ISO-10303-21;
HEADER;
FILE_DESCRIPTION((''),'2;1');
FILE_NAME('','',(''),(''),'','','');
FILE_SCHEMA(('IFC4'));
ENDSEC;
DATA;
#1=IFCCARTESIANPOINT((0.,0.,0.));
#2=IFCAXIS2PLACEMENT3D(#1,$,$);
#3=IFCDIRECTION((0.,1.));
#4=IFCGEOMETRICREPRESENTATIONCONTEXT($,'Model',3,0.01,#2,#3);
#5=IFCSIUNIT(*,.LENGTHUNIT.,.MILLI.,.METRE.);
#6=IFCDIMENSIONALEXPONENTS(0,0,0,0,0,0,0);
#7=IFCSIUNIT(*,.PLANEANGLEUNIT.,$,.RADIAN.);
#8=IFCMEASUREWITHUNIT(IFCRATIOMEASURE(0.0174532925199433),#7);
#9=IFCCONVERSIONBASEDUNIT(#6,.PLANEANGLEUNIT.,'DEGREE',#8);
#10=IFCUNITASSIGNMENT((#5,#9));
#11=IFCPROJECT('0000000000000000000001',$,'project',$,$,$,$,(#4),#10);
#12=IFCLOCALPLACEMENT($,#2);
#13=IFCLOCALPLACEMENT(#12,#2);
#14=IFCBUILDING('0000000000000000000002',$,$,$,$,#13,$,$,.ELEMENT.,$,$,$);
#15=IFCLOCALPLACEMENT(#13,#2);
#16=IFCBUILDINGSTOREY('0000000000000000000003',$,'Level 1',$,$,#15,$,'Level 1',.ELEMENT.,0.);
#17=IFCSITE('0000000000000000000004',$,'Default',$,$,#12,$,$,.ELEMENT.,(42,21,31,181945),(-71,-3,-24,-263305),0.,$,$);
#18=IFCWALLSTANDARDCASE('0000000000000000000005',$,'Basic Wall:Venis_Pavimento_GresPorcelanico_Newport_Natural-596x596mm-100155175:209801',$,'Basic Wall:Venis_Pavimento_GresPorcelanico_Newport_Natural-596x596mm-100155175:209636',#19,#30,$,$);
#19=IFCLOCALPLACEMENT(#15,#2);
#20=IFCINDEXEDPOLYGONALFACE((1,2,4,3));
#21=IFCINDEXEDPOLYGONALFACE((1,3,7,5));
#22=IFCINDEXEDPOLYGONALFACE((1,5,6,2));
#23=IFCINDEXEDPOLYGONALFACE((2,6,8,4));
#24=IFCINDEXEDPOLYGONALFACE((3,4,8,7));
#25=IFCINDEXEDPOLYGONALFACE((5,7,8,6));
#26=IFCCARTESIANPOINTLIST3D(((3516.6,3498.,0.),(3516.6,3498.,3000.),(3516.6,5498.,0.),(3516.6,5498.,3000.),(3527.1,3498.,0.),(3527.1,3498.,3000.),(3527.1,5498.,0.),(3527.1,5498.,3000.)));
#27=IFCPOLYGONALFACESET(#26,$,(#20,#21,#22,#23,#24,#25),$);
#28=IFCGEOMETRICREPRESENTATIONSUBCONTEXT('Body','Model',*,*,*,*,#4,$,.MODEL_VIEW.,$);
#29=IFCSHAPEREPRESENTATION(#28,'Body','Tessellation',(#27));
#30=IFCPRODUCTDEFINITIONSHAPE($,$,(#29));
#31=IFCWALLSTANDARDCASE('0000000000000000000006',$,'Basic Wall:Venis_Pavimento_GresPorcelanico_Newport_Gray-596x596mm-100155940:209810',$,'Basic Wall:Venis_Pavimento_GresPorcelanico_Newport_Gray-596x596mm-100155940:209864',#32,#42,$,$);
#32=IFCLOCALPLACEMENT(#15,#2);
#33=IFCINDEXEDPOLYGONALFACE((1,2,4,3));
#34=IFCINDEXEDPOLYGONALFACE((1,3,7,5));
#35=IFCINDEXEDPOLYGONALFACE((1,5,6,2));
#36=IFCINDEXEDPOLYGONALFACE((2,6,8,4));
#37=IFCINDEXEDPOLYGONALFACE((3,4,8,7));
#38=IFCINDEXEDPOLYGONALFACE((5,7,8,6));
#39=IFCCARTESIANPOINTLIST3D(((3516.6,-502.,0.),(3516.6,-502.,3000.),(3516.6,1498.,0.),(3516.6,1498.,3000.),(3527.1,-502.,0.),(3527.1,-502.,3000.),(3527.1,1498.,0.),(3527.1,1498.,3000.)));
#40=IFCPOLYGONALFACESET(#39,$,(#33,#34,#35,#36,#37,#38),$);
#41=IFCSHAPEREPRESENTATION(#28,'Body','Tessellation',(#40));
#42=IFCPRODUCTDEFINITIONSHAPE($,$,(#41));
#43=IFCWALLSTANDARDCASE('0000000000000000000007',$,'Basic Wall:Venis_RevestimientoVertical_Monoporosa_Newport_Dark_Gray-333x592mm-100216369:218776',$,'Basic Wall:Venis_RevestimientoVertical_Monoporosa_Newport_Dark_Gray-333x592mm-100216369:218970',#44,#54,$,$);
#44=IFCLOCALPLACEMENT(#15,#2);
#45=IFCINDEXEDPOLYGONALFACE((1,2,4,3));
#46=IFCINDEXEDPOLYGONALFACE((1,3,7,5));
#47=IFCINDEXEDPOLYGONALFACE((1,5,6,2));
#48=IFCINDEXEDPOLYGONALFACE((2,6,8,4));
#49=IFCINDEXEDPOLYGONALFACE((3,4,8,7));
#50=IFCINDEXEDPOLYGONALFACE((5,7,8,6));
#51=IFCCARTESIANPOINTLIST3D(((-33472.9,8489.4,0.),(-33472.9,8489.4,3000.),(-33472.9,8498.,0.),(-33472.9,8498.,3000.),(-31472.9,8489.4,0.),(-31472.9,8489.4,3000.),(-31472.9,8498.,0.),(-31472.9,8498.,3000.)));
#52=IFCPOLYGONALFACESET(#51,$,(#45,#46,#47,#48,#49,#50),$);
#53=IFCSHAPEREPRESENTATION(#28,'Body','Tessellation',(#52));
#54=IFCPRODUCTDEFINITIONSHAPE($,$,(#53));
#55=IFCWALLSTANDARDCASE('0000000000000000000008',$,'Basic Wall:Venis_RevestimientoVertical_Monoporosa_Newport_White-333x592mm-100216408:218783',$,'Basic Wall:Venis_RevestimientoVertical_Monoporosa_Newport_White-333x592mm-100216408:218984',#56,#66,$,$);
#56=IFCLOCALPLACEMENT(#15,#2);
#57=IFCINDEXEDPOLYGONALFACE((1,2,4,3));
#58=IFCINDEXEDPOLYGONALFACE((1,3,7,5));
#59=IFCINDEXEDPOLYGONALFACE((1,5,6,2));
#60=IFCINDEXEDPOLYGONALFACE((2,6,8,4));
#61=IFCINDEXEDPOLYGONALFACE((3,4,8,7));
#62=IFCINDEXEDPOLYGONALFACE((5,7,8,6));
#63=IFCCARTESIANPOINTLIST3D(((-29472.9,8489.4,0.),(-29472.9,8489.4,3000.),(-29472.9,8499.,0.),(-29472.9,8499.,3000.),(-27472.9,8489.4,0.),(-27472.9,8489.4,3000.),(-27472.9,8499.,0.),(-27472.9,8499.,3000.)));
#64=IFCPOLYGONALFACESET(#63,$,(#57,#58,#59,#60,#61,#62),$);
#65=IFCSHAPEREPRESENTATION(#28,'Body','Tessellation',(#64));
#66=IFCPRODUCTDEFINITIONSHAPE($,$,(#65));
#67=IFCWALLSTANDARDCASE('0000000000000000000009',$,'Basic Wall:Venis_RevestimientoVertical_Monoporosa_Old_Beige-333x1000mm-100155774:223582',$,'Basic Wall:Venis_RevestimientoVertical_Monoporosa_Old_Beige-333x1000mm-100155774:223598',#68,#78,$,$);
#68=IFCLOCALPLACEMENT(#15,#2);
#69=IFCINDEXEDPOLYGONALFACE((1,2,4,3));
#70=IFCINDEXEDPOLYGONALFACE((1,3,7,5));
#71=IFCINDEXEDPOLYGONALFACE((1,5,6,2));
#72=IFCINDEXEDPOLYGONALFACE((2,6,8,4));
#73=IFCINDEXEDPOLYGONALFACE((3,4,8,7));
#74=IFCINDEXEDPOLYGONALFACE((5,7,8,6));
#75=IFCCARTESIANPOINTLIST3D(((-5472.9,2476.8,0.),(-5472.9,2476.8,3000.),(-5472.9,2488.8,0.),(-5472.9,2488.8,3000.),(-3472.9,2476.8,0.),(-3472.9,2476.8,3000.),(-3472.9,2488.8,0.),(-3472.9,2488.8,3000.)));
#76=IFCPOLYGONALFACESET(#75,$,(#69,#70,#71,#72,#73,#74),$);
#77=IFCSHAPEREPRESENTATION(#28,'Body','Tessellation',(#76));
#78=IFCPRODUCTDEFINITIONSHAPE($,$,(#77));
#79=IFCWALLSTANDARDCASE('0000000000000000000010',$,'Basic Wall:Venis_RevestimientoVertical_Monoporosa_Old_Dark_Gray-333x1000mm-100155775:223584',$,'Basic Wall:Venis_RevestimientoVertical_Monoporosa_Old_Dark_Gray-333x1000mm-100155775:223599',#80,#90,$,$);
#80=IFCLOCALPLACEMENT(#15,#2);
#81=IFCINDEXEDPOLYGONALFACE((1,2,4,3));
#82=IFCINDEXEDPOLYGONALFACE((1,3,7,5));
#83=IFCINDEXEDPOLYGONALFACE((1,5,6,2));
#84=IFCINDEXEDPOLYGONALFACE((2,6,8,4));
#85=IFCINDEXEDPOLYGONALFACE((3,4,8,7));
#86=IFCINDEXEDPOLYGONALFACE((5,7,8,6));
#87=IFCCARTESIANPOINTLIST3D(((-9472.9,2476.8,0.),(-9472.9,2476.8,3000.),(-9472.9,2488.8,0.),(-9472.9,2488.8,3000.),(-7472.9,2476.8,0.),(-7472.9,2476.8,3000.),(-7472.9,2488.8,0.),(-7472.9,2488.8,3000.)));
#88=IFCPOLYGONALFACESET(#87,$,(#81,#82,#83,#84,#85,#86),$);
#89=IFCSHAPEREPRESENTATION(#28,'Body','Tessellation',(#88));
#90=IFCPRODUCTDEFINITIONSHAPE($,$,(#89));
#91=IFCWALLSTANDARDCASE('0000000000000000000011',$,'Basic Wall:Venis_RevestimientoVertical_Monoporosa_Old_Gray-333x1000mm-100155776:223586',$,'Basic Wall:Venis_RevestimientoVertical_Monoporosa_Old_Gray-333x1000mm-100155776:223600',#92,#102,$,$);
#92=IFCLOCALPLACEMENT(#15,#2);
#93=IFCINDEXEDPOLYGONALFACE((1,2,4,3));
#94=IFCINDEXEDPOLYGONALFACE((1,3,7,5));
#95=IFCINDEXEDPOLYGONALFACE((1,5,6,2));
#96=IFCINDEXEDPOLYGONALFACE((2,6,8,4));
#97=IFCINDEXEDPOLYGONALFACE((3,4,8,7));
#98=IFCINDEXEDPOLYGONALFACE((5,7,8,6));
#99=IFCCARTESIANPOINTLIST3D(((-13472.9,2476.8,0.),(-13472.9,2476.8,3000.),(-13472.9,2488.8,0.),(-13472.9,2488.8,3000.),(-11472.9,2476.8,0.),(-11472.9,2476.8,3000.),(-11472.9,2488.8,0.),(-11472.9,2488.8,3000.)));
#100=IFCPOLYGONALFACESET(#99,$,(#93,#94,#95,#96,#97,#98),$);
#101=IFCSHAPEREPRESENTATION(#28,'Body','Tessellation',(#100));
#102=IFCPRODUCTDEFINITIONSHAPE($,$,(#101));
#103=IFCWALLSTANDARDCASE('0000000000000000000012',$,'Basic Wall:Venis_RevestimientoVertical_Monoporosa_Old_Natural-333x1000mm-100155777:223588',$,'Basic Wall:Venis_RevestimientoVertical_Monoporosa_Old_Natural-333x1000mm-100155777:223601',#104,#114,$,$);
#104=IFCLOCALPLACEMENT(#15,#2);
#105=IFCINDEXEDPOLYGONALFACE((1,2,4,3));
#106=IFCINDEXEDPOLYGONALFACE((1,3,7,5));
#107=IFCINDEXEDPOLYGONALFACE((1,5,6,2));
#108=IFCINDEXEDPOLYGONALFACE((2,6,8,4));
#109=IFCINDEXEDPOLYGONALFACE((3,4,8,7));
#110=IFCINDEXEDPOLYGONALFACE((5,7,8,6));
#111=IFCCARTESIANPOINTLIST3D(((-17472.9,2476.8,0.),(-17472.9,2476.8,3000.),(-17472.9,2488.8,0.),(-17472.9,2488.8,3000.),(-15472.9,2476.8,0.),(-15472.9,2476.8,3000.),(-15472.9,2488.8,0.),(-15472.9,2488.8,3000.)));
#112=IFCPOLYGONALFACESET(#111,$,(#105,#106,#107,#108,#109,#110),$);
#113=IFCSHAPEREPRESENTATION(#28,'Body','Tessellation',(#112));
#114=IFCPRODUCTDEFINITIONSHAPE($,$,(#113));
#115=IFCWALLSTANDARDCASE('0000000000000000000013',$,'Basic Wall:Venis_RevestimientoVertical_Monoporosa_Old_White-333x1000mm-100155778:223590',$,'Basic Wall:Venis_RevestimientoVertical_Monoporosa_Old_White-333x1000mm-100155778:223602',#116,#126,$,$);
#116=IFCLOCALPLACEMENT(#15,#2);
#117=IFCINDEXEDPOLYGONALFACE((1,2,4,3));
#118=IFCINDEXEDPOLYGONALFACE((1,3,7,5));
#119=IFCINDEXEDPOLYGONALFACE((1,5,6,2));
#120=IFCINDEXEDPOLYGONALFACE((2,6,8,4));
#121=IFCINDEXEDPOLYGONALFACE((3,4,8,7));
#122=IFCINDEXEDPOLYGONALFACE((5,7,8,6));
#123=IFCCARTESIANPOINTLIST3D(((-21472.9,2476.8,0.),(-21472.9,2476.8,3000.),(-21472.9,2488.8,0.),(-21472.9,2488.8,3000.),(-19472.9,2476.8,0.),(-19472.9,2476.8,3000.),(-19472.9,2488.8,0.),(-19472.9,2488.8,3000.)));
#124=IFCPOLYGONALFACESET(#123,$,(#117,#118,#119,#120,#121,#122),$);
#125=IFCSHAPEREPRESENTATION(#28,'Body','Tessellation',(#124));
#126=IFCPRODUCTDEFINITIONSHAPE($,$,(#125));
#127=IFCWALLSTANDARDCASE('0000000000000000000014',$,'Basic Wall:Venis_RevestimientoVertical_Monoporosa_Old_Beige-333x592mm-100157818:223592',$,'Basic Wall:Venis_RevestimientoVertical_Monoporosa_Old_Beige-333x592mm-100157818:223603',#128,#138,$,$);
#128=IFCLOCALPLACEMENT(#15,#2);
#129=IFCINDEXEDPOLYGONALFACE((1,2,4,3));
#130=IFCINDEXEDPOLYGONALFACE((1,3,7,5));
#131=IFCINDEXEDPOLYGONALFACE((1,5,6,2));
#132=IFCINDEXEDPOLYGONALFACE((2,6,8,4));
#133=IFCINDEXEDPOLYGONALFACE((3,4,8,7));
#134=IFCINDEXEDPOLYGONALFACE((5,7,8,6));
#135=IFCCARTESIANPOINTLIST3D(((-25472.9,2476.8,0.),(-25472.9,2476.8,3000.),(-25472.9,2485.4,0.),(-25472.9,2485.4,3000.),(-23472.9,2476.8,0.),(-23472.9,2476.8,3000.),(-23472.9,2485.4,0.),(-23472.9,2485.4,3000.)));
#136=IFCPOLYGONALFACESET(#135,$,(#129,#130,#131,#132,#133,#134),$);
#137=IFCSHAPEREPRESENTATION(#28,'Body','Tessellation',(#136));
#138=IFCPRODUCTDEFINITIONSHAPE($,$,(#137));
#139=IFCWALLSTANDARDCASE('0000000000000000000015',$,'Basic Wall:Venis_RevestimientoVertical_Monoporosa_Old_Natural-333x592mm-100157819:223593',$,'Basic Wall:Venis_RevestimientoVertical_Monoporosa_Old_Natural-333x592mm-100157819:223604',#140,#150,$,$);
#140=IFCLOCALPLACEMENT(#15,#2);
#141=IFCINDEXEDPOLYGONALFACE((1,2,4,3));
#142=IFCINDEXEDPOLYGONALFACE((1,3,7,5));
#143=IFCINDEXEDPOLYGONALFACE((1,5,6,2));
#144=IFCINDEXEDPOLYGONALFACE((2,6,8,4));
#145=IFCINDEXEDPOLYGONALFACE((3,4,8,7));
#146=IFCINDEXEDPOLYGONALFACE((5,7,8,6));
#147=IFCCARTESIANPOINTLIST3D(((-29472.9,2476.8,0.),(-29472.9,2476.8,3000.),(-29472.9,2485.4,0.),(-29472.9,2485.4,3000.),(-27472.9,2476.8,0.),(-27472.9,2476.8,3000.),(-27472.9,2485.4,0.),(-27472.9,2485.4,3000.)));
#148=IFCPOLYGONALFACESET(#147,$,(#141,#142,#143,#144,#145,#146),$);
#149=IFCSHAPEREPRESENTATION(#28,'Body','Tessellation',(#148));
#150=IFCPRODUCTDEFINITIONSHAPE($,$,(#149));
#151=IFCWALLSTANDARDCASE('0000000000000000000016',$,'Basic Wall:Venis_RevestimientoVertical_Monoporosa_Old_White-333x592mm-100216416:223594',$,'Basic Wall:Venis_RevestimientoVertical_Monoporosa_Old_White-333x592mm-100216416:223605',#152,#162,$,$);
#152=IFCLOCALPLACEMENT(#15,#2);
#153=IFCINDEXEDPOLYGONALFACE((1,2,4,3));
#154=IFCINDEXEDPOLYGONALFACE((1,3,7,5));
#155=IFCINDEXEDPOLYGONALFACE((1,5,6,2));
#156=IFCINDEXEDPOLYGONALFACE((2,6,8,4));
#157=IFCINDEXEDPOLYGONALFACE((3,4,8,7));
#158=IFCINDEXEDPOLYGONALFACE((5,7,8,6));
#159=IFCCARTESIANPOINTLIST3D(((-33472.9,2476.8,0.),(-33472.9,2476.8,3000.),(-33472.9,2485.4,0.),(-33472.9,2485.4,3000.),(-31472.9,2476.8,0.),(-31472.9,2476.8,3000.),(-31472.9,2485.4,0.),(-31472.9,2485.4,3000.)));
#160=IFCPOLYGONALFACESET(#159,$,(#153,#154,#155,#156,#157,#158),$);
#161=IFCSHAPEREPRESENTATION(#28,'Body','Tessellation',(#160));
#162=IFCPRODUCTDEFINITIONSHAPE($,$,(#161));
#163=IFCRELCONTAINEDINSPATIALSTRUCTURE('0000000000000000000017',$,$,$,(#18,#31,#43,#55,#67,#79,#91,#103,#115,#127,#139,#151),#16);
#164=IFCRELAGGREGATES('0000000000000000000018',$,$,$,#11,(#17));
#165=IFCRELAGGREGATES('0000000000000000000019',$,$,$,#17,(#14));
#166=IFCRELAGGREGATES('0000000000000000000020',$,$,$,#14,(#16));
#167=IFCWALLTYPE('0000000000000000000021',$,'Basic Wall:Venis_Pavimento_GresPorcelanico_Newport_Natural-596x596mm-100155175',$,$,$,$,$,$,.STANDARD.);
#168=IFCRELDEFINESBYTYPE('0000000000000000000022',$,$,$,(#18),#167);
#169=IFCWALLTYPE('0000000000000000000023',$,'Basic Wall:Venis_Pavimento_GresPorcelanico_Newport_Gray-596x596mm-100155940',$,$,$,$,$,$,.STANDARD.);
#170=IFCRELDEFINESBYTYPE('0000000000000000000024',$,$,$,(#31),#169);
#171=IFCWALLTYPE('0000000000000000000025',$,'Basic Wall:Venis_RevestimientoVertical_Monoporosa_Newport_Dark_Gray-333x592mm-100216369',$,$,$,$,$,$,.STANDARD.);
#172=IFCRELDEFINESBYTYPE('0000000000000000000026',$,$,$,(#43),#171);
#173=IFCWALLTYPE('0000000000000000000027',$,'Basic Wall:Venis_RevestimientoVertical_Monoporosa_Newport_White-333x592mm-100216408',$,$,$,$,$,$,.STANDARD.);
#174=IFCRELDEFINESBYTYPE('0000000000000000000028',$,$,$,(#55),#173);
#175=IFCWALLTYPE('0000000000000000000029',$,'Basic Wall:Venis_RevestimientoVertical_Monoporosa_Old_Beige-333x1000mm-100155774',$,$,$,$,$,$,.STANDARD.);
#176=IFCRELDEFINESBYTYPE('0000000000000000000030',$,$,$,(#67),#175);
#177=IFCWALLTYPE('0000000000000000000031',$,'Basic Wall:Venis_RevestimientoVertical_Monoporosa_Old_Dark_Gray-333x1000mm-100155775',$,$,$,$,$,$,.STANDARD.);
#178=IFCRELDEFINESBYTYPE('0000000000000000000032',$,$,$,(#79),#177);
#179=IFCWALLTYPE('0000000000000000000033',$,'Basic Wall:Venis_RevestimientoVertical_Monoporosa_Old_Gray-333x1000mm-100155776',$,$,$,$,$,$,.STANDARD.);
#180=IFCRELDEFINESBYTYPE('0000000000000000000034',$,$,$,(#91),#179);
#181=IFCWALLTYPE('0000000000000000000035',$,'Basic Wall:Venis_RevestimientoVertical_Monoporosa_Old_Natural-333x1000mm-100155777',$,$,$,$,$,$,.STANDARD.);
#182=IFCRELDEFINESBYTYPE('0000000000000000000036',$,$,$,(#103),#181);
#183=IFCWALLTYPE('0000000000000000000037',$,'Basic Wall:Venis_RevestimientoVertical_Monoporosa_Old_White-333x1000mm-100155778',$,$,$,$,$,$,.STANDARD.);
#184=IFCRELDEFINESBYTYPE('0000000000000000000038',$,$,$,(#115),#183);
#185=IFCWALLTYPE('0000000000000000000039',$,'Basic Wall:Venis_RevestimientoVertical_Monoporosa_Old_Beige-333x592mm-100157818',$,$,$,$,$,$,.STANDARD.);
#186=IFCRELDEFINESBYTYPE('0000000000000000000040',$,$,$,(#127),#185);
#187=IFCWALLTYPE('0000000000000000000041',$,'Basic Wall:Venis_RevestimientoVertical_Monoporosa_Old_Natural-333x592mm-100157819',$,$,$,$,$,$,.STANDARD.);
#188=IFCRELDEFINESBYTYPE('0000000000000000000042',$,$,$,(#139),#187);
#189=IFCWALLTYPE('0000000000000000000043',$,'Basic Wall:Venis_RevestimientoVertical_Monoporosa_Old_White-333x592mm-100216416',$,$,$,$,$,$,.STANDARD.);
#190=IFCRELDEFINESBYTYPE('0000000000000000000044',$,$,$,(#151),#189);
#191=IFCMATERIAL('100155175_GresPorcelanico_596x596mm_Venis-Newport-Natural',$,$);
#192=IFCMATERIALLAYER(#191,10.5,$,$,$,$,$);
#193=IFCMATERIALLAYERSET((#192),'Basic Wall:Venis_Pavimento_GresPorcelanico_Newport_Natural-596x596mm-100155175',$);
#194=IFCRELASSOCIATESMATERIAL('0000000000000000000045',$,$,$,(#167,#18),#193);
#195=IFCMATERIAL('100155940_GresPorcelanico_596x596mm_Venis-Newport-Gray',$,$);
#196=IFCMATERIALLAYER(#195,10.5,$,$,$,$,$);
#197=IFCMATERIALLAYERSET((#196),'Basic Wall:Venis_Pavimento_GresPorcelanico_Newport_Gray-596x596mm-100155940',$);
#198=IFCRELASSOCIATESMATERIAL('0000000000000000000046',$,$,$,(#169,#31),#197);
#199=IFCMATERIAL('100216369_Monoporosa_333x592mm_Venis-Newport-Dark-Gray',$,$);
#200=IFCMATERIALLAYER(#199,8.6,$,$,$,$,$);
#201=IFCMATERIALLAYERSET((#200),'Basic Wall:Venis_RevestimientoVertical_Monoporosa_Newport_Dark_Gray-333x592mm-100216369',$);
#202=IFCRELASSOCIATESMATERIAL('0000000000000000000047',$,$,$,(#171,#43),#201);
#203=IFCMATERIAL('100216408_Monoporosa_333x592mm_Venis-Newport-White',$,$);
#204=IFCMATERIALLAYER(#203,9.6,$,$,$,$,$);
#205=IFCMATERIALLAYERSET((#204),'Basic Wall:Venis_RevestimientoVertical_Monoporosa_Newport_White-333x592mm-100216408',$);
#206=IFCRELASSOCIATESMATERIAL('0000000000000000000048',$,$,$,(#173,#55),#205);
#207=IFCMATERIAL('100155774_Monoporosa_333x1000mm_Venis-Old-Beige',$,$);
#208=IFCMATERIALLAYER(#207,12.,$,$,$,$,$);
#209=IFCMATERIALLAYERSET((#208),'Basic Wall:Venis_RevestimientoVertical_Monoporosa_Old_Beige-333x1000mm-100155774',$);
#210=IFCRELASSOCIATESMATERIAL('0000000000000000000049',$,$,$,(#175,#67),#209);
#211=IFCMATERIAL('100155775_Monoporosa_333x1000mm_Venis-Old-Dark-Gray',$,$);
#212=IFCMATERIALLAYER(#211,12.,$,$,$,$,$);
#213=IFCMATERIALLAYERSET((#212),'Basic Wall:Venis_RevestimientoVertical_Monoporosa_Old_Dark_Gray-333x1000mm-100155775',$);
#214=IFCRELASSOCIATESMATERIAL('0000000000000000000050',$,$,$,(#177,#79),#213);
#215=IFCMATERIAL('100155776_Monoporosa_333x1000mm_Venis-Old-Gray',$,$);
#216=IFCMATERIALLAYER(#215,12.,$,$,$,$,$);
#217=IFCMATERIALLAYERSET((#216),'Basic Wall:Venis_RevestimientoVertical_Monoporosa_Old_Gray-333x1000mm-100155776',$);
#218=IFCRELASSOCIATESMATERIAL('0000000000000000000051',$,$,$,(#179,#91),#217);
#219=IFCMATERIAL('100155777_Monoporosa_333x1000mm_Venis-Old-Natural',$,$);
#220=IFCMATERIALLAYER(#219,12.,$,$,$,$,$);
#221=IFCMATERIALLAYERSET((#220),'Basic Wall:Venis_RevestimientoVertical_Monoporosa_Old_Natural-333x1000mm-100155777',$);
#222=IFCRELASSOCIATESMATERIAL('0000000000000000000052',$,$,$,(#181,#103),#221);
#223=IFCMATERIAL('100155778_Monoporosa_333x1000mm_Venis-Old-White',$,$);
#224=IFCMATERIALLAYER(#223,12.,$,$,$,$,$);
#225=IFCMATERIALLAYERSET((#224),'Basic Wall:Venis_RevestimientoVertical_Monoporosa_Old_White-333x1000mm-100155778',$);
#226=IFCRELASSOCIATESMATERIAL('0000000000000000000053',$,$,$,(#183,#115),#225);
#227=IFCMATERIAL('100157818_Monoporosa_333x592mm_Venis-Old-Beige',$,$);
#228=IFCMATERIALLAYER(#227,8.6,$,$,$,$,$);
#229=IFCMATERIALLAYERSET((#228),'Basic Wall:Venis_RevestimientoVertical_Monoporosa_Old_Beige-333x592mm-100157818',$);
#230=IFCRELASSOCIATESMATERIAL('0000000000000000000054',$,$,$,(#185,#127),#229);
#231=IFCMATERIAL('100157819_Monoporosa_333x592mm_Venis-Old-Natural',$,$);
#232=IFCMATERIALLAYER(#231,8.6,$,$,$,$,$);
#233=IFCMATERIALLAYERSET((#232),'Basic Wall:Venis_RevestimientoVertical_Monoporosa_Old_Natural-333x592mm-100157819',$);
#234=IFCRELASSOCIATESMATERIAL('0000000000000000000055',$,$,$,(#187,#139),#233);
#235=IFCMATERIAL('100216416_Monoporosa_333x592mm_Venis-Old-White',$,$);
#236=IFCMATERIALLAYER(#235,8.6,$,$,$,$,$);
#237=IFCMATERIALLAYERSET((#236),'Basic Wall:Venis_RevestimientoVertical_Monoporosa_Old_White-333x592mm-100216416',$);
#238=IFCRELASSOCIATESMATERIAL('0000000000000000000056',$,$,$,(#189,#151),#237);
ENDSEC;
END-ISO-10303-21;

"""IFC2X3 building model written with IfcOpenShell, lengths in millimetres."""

from ifc_helpers import new_model, entity, si_unit, converted_unit, direction, frame, frame_2d, origin, place, context, subcontext, project, spatial, rectangle, extrude, material, layer, layer_set, layer_usage, type_object, element, save


model = new_model("IFC2X3")

# Units and contexts
model_context = context("Model", 3, precision=0.01, world=origin(), true_north=direction((0.0, 1.0)))
body_context = subcontext(model_context, "Body", "Model", "MODEL_VIEW")
ifc_project = project(units=[si_unit("LENGTHUNIT", "METRE", prefix="MILLI"), converted_unit("PLANEANGLEUNIT", "DEGREE", entity("IfcRatioMeasure", 0.0174532925199433), si_unit("PLANEANGLEUNIT", "RADIAN"), dimensions=[0, 0, 0, 0, 0, 0, 0])], contexts=[model_context])

# Site, building, storey
site_placement = place(None, origin())
site = spatial("IfcSite", under=ifc_project, at=site_placement, Name="Default", CompositionType="ELEMENT", RefLatitude=(42, 21, 31, 181945), RefLongitude=(-71, -3, -24, -263305), RefElevation=0.0)
building_placement = place(site_placement, origin())
building = spatial("IfcBuilding", under=site, at=building_placement, CompositionType="ELEMENT")
storey_placement = place(building_placement, origin())
storey = spatial("IfcBuildingStorey", under=building, at=storey_placement, Name="Level 1", LongName="Level 1", CompositionType="ELEMENT", Elevation=0.0)

# Walls
ifc_material_1 = material(Name="100155175_GresPorcelanico_596x596mm_Venis-Newport-Natural")
ifc_layer_1 = layer(ifc_material_1, 10.5)
ifc_layer_set_1 = layer_set([ifc_layer_1], Name="Basic Wall:Venis_Pavimento_GresPorcelanico_Newport_Natural-596x596mm-100155175")
ifc_layer_usage_1 = layer_usage(ifc_layer_set_1, "AXIS2", "POSITIVE", -5.2)
wall_type_1 = type_object("IfcWallType", Name="Basic Wall:Venis_Pavimento_GresPorcelanico_Newport_Natural-596x596mm-100155175", PredefinedType="STANDARD", material=ifc_layer_set_1)
wall_1_placement = place(storey_placement, frame((3521.8, 5498.0, 0.0), z_axis=(0.0, 0.0, 1.0), x_axis=(0.0, -1.0, 0.0)))
element("IfcWallStandardCase", 1, at=wall_1_placement, inside=storey, type_object=wall_type_1, material=ifc_layer_usage_1, Name="Basic Wall:Venis_Pavimento_GresPorcelanico_Newport_Natural-596x596mm-100155175:209801", ObjectType="Basic Wall:Venis_Pavimento_GresPorcelanico_Newport_Natural-596x596mm-100155175:209636", context=body_context, shape_type="SweptSolid", body=[
    extrude(rectangle(XDim=2000.0, YDim=10.5, at=frame_2d((1000.0, 0.0), x_axis=(-1.0, 0.0))), origin(), (0.0, 0.0, 1.0), 3000.0),
])
ifc_material_2 = material(Name="100155940_GresPorcelanico_596x596mm_Venis-Newport-Gray")
ifc_layer_2 = layer(ifc_material_2, 10.5)
ifc_layer_set_2 = layer_set([ifc_layer_2], Name="Basic Wall:Venis_Pavimento_GresPorcelanico_Newport_Gray-596x596mm-100155940")
ifc_layer_usage_2 = layer_usage(ifc_layer_set_2, "AXIS2", "POSITIVE", -5.2)
wall_type_2 = type_object("IfcWallType", Name="Basic Wall:Venis_Pavimento_GresPorcelanico_Newport_Gray-596x596mm-100155940", PredefinedType="STANDARD", material=ifc_layer_set_2)
wall_2_placement = place(storey_placement, frame((3521.8, 1498.0, 0.0), z_axis=(0.0, 0.0, 1.0), x_axis=(0.0, -1.0, 0.0)))
element("IfcWallStandardCase", 2, at=wall_2_placement, inside=storey, type_object=wall_type_2, material=ifc_layer_usage_2, Name="Basic Wall:Venis_Pavimento_GresPorcelanico_Newport_Gray-596x596mm-100155940:209810", ObjectType="Basic Wall:Venis_Pavimento_GresPorcelanico_Newport_Gray-596x596mm-100155940:209864", context=body_context, shape_type="SweptSolid", body=[
    extrude(rectangle(XDim=2000.0, YDim=10.5, at=frame_2d((1000.0, 0.0), x_axis=(-1.0, 0.0))), origin(), (0.0, 0.0, 1.0), 3000.0),
])
ifc_material_3 = material(Name="100216369_Monoporosa_333x592mm_Venis-Newport-Dark-Gray")
ifc_layer_3 = layer(ifc_material_3, 8.6)
ifc_layer_set_3 = layer_set([ifc_layer_3], Name="Basic Wall:Venis_RevestimientoVertical_Monoporosa_Newport_Dark_Gray-333x592mm-100216369")
ifc_layer_usage_3 = layer_usage(ifc_layer_set_3, "AXIS2", "POSITIVE", -4.3)
wall_type_3 = type_object("IfcWallType", Name="Basic Wall:Venis_RevestimientoVertical_Monoporosa_Newport_Dark_Gray-333x592mm-100216369", PredefinedType="STANDARD", material=ifc_layer_set_3)
wall_3_placement = place(storey_placement, frame((-33472.9, 8493.7, 0.0)))
element("IfcWallStandardCase", 3, at=wall_3_placement, inside=storey, type_object=wall_type_3, material=ifc_layer_usage_3, Name="Basic Wall:Venis_RevestimientoVertical_Monoporosa_Newport_Dark_Gray-333x592mm-100216369:218776", ObjectType="Basic Wall:Venis_RevestimientoVertical_Monoporosa_Newport_Dark_Gray-333x592mm-100216369:218970", context=body_context, shape_type="SweptSolid", body=[
    extrude(rectangle(XDim=2000.0, YDim=8.6, at=frame_2d((1000.0, 0.0), x_axis=(-1.0, 0.0))), origin(), (0.0, 0.0, 1.0), 3000.0),
])
ifc_material_4 = material(Name="100216408_Monoporosa_333x592mm_Venis-Newport-White")
ifc_layer_4 = layer(ifc_material_4, 9.6)
ifc_layer_set_4 = layer_set([ifc_layer_4], Name="Basic Wall:Venis_RevestimientoVertical_Monoporosa_Newport_White-333x592mm-100216408")
ifc_layer_usage_4 = layer_usage(ifc_layer_set_4, "AXIS2", "POSITIVE", -4.8)
wall_type_4 = type_object("IfcWallType", Name="Basic Wall:Venis_RevestimientoVertical_Monoporosa_Newport_White-333x592mm-100216408", PredefinedType="STANDARD", material=ifc_layer_set_4)
wall_4_placement = place(storey_placement, frame((-29472.9, 8494.2, 0.0)))
element("IfcWallStandardCase", 4, at=wall_4_placement, inside=storey, type_object=wall_type_4, material=ifc_layer_usage_4, Name="Basic Wall:Venis_RevestimientoVertical_Monoporosa_Newport_White-333x592mm-100216408:218783", ObjectType="Basic Wall:Venis_RevestimientoVertical_Monoporosa_Newport_White-333x592mm-100216408:218984", context=body_context, shape_type="SweptSolid", body=[
    extrude(rectangle(XDim=2000.0, YDim=9.6, at=frame_2d((1000.0, 0.0), x_axis=(-1.0, 0.0))), origin(), (0.0, 0.0, 1.0), 3000.0),
])
ifc_material_5 = material(Name="100155774_Monoporosa_333x1000mm_Venis-Old-Beige")
ifc_layer_5 = layer(ifc_material_5, 12.0)
ifc_layer_set_5 = layer_set([ifc_layer_5], Name="Basic Wall:Venis_RevestimientoVertical_Monoporosa_Old_Beige-333x1000mm-100155774")
ifc_layer_usage_5 = layer_usage(ifc_layer_set_5, "AXIS2", "POSITIVE", -6.0)
wall_type_5 = type_object("IfcWallType", Name="Basic Wall:Venis_RevestimientoVertical_Monoporosa_Old_Beige-333x1000mm-100155774", PredefinedType="STANDARD", material=ifc_layer_set_5)
wall_5_placement = place(storey_placement, frame((-3472.9, 2482.8, 0.0), z_axis=(0.0, 0.0, 1.0), x_axis=(-1.0, 0.0, 0.0)))
element("IfcWallStandardCase", 5, at=wall_5_placement, inside=storey, type_object=wall_type_5, material=ifc_layer_usage_5, Name="Basic Wall:Venis_RevestimientoVertical_Monoporosa_Old_Beige-333x1000mm-100155774:223582", ObjectType="Basic Wall:Venis_RevestimientoVertical_Monoporosa_Old_Beige-333x1000mm-100155774:223598", context=body_context, shape_type="SweptSolid", body=[
    extrude(rectangle(XDim=2000.0, YDim=12.0, at=frame_2d((1000.0, 0.0), x_axis=(-1.0, 0.0))), origin(), (0.0, 0.0, 1.0), 3000.0),
])
ifc_material_6 = material(Name="100155775_Monoporosa_333x1000mm_Venis-Old-Dark-Gray")
ifc_layer_6 = layer(ifc_material_6, 12.0)
ifc_layer_set_6 = layer_set([ifc_layer_6], Name="Basic Wall:Venis_RevestimientoVertical_Monoporosa_Old_Dark_Gray-333x1000mm-100155775")
ifc_layer_usage_6 = layer_usage(ifc_layer_set_6, "AXIS2", "POSITIVE", -6.0)
wall_type_6 = type_object("IfcWallType", Name="Basic Wall:Venis_RevestimientoVertical_Monoporosa_Old_Dark_Gray-333x1000mm-100155775", PredefinedType="STANDARD", material=ifc_layer_set_6)
wall_6_placement = place(storey_placement, frame((-7472.9, 2482.8, 0.0), z_axis=(0.0, 0.0, 1.0), x_axis=(-1.0, 0.0, 0.0)))
element("IfcWallStandardCase", 6, at=wall_6_placement, inside=storey, type_object=wall_type_6, material=ifc_layer_usage_6, Name="Basic Wall:Venis_RevestimientoVertical_Monoporosa_Old_Dark_Gray-333x1000mm-100155775:223584", ObjectType="Basic Wall:Venis_RevestimientoVertical_Monoporosa_Old_Dark_Gray-333x1000mm-100155775:223599", context=body_context, shape_type="SweptSolid", body=[
    extrude(rectangle(XDim=2000.0, YDim=12.0, at=frame_2d((1000.0, 0.0), x_axis=(-1.0, 0.0))), origin(), (0.0, 0.0, 1.0), 3000.0),
])
ifc_material_7 = material(Name="100155776_Monoporosa_333x1000mm_Venis-Old-Gray")
ifc_layer_7 = layer(ifc_material_7, 12.0)
ifc_layer_set_7 = layer_set([ifc_layer_7], Name="Basic Wall:Venis_RevestimientoVertical_Monoporosa_Old_Gray-333x1000mm-100155776")
ifc_layer_usage_7 = layer_usage(ifc_layer_set_7, "AXIS2", "POSITIVE", -6.0)
wall_type_7 = type_object("IfcWallType", Name="Basic Wall:Venis_RevestimientoVertical_Monoporosa_Old_Gray-333x1000mm-100155776", PredefinedType="STANDARD", material=ifc_layer_set_7)
wall_7_placement = place(storey_placement, frame((-11472.9, 2482.8, 0.0), z_axis=(0.0, 0.0, 1.0), x_axis=(-1.0, 0.0, 0.0)))
element("IfcWallStandardCase", 7, at=wall_7_placement, inside=storey, type_object=wall_type_7, material=ifc_layer_usage_7, Name="Basic Wall:Venis_RevestimientoVertical_Monoporosa_Old_Gray-333x1000mm-100155776:223586", ObjectType="Basic Wall:Venis_RevestimientoVertical_Monoporosa_Old_Gray-333x1000mm-100155776:223600", context=body_context, shape_type="SweptSolid", body=[
    extrude(rectangle(XDim=2000.0, YDim=12.0, at=frame_2d((1000.0, 0.0), x_axis=(-1.0, 0.0))), origin(), (0.0, 0.0, 1.0), 3000.0),
])
ifc_material_8 = material(Name="100155777_Monoporosa_333x1000mm_Venis-Old-Natural")
ifc_layer_8 = layer(ifc_material_8, 12.0)
ifc_layer_set_8 = layer_set([ifc_layer_8], Name="Basic Wall:Venis_RevestimientoVertical_Monoporosa_Old_Natural-333x1000mm-100155777")
ifc_layer_usage_8 = layer_usage(ifc_layer_set_8, "AXIS2", "POSITIVE", -6.0)
wall_type_8 = type_object("IfcWallType", Name="Basic Wall:Venis_RevestimientoVertical_Monoporosa_Old_Natural-333x1000mm-100155777", PredefinedType="STANDARD", material=ifc_layer_set_8)
wall_8_placement = place(storey_placement, frame((-15472.9, 2482.8, 0.0), z_axis=(0.0, 0.0, 1.0), x_axis=(-1.0, 0.0, 0.0)))
element("IfcWallStandardCase", 8, at=wall_8_placement, inside=storey, type_object=wall_type_8, material=ifc_layer_usage_8, Name="Basic Wall:Venis_RevestimientoVertical_Monoporosa_Old_Natural-333x1000mm-100155777:223588", ObjectType="Basic Wall:Venis_RevestimientoVertical_Monoporosa_Old_Natural-333x1000mm-100155777:223601", context=body_context, shape_type="SweptSolid", body=[
    extrude(rectangle(XDim=2000.0, YDim=12.0, at=frame_2d((1000.0, 0.0), x_axis=(-1.0, 0.0))), origin(), (0.0, 0.0, 1.0), 3000.0),
])
ifc_material_9 = material(Name="100155778_Monoporosa_333x1000mm_Venis-Old-White")
ifc_layer_9 = layer(ifc_material_9, 12.0)
ifc_layer_set_9 = layer_set([ifc_layer_9], Name="Basic Wall:Venis_RevestimientoVertical_Monoporosa_Old_White-333x1000mm-100155778")
ifc_layer_usage_9 = layer_usage(ifc_layer_set_9, "AXIS2", "POSITIVE", -6.0)
wall_type_9 = type_object("IfcWallType", Name="Basic Wall:Venis_RevestimientoVertical_Monoporosa_Old_White-333x1000mm-100155778", PredefinedType="STANDARD", material=ifc_layer_set_9)
wall_9_placement = place(storey_placement, frame((-19472.9, 2482.8, 0.0), z_axis=(0.0, 0.0, 1.0), x_axis=(-1.0, 0.0, 0.0)))
element("IfcWallStandardCase", 9, at=wall_9_placement, inside=storey, type_object=wall_type_9, material=ifc_layer_usage_9, Name="Basic Wall:Venis_RevestimientoVertical_Monoporosa_Old_White-333x1000mm-100155778:223590", ObjectType="Basic Wall:Venis_RevestimientoVertical_Monoporosa_Old_White-333x1000mm-100155778:223602", context=body_context, shape_type="SweptSolid", body=[
    extrude(rectangle(XDim=2000.0, YDim=12.0, at=frame_2d((1000.0, 0.0), x_axis=(-1.0, 0.0))), origin(), (0.0, 0.0, 1.0), 3000.0),
])
ifc_material_10 = material(Name="100157818_Monoporosa_333x592mm_Venis-Old-Beige")
ifc_layer_10 = layer(ifc_material_10, 8.6)
ifc_layer_set_10 = layer_set([ifc_layer_10], Name="Basic Wall:Venis_RevestimientoVertical_Monoporosa_Old_Beige-333x592mm-100157818")
ifc_layer_usage_10 = layer_usage(ifc_layer_set_10, "AXIS2", "POSITIVE", -4.3)
wall_type_10 = type_object("IfcWallType", Name="Basic Wall:Venis_RevestimientoVertical_Monoporosa_Old_Beige-333x592mm-100157818", PredefinedType="STANDARD", material=ifc_layer_set_10)
wall_10_placement = place(storey_placement, frame((-23472.9, 2481.1, 0.0), z_axis=(0.0, 0.0, 1.0), x_axis=(-1.0, 0.0, 0.0)))
element("IfcWallStandardCase", 10, at=wall_10_placement, inside=storey, type_object=wall_type_10, material=ifc_layer_usage_10, Name="Basic Wall:Venis_RevestimientoVertical_Monoporosa_Old_Beige-333x592mm-100157818:223592", ObjectType="Basic Wall:Venis_RevestimientoVertical_Monoporosa_Old_Beige-333x592mm-100157818:223603", context=body_context, shape_type="SweptSolid", body=[
    extrude(rectangle(XDim=2000.0, YDim=8.6, at=frame_2d((1000.0, 0.0), x_axis=(-1.0, 0.0))), origin(), (0.0, 0.0, 1.0), 3000.0),
])
ifc_material_11 = material(Name="100157819_Monoporosa_333x592mm_Venis-Old-Natural")
ifc_layer_11 = layer(ifc_material_11, 8.6)
ifc_layer_set_11 = layer_set([ifc_layer_11], Name="Basic Wall:Venis_RevestimientoVertical_Monoporosa_Old_Natural-333x592mm-100157819")
ifc_layer_usage_11 = layer_usage(ifc_layer_set_11, "AXIS2", "POSITIVE", -4.3)
wall_type_11 = type_object("IfcWallType", Name="Basic Wall:Venis_RevestimientoVertical_Monoporosa_Old_Natural-333x592mm-100157819", PredefinedType="STANDARD", material=ifc_layer_set_11)
wall_11_placement = place(storey_placement, frame((-27472.9, 2481.1, 0.0), z_axis=(0.0, 0.0, 1.0), x_axis=(-1.0, 0.0, 0.0)))
element("IfcWallStandardCase", 11, at=wall_11_placement, inside=storey, type_object=wall_type_11, material=ifc_layer_usage_11, Name="Basic Wall:Venis_RevestimientoVertical_Monoporosa_Old_Natural-333x592mm-100157819:223593", ObjectType="Basic Wall:Venis_RevestimientoVertical_Monoporosa_Old_Natural-333x592mm-100157819:223604", context=body_context, shape_type="SweptSolid", body=[
    extrude(rectangle(XDim=2000.0, YDim=8.6, at=frame_2d((1000.0, 0.0), x_axis=(-1.0, 0.0))), origin(), (0.0, 0.0, 1.0), 3000.0),
])
ifc_material_12 = material(Name="100216416_Monoporosa_333x592mm_Venis-Old-White")
ifc_layer_12 = layer(ifc_material_12, 8.6)
ifc_layer_set_12 = layer_set([ifc_layer_12], Name="Basic Wall:Venis_RevestimientoVertical_Monoporosa_Old_White-333x592mm-100216416")
ifc_layer_usage_12 = layer_usage(ifc_layer_set_12, "AXIS2", "POSITIVE", -4.3)
wall_type_12 = type_object("IfcWallType", Name="Basic Wall:Venis_RevestimientoVertical_Monoporosa_Old_White-333x592mm-100216416", PredefinedType="STANDARD", material=ifc_layer_set_12)
wall_12_placement = place(storey_placement, frame((-31472.9, 2481.1, 0.0), z_axis=(0.0, 0.0, 1.0), x_axis=(-1.0, 0.0, 0.0)))
element("IfcWallStandardCase", 12, at=wall_12_placement, inside=storey, type_object=wall_type_12, material=ifc_layer_usage_12, Name="Basic Wall:Venis_RevestimientoVertical_Monoporosa_Old_White-333x592mm-100216416:223594", ObjectType="Basic Wall:Venis_RevestimientoVertical_Monoporosa_Old_White-333x592mm-100216416:223605", context=body_context, shape_type="SweptSolid", body=[
    extrude(rectangle(XDim=2000.0, YDim=8.6, at=frame_2d((1000.0, 0.0), x_axis=(-1.0, 0.0))), origin(), (0.0, 0.0, 1.0), 3000.0),
])

save(model, "model.ifc")
